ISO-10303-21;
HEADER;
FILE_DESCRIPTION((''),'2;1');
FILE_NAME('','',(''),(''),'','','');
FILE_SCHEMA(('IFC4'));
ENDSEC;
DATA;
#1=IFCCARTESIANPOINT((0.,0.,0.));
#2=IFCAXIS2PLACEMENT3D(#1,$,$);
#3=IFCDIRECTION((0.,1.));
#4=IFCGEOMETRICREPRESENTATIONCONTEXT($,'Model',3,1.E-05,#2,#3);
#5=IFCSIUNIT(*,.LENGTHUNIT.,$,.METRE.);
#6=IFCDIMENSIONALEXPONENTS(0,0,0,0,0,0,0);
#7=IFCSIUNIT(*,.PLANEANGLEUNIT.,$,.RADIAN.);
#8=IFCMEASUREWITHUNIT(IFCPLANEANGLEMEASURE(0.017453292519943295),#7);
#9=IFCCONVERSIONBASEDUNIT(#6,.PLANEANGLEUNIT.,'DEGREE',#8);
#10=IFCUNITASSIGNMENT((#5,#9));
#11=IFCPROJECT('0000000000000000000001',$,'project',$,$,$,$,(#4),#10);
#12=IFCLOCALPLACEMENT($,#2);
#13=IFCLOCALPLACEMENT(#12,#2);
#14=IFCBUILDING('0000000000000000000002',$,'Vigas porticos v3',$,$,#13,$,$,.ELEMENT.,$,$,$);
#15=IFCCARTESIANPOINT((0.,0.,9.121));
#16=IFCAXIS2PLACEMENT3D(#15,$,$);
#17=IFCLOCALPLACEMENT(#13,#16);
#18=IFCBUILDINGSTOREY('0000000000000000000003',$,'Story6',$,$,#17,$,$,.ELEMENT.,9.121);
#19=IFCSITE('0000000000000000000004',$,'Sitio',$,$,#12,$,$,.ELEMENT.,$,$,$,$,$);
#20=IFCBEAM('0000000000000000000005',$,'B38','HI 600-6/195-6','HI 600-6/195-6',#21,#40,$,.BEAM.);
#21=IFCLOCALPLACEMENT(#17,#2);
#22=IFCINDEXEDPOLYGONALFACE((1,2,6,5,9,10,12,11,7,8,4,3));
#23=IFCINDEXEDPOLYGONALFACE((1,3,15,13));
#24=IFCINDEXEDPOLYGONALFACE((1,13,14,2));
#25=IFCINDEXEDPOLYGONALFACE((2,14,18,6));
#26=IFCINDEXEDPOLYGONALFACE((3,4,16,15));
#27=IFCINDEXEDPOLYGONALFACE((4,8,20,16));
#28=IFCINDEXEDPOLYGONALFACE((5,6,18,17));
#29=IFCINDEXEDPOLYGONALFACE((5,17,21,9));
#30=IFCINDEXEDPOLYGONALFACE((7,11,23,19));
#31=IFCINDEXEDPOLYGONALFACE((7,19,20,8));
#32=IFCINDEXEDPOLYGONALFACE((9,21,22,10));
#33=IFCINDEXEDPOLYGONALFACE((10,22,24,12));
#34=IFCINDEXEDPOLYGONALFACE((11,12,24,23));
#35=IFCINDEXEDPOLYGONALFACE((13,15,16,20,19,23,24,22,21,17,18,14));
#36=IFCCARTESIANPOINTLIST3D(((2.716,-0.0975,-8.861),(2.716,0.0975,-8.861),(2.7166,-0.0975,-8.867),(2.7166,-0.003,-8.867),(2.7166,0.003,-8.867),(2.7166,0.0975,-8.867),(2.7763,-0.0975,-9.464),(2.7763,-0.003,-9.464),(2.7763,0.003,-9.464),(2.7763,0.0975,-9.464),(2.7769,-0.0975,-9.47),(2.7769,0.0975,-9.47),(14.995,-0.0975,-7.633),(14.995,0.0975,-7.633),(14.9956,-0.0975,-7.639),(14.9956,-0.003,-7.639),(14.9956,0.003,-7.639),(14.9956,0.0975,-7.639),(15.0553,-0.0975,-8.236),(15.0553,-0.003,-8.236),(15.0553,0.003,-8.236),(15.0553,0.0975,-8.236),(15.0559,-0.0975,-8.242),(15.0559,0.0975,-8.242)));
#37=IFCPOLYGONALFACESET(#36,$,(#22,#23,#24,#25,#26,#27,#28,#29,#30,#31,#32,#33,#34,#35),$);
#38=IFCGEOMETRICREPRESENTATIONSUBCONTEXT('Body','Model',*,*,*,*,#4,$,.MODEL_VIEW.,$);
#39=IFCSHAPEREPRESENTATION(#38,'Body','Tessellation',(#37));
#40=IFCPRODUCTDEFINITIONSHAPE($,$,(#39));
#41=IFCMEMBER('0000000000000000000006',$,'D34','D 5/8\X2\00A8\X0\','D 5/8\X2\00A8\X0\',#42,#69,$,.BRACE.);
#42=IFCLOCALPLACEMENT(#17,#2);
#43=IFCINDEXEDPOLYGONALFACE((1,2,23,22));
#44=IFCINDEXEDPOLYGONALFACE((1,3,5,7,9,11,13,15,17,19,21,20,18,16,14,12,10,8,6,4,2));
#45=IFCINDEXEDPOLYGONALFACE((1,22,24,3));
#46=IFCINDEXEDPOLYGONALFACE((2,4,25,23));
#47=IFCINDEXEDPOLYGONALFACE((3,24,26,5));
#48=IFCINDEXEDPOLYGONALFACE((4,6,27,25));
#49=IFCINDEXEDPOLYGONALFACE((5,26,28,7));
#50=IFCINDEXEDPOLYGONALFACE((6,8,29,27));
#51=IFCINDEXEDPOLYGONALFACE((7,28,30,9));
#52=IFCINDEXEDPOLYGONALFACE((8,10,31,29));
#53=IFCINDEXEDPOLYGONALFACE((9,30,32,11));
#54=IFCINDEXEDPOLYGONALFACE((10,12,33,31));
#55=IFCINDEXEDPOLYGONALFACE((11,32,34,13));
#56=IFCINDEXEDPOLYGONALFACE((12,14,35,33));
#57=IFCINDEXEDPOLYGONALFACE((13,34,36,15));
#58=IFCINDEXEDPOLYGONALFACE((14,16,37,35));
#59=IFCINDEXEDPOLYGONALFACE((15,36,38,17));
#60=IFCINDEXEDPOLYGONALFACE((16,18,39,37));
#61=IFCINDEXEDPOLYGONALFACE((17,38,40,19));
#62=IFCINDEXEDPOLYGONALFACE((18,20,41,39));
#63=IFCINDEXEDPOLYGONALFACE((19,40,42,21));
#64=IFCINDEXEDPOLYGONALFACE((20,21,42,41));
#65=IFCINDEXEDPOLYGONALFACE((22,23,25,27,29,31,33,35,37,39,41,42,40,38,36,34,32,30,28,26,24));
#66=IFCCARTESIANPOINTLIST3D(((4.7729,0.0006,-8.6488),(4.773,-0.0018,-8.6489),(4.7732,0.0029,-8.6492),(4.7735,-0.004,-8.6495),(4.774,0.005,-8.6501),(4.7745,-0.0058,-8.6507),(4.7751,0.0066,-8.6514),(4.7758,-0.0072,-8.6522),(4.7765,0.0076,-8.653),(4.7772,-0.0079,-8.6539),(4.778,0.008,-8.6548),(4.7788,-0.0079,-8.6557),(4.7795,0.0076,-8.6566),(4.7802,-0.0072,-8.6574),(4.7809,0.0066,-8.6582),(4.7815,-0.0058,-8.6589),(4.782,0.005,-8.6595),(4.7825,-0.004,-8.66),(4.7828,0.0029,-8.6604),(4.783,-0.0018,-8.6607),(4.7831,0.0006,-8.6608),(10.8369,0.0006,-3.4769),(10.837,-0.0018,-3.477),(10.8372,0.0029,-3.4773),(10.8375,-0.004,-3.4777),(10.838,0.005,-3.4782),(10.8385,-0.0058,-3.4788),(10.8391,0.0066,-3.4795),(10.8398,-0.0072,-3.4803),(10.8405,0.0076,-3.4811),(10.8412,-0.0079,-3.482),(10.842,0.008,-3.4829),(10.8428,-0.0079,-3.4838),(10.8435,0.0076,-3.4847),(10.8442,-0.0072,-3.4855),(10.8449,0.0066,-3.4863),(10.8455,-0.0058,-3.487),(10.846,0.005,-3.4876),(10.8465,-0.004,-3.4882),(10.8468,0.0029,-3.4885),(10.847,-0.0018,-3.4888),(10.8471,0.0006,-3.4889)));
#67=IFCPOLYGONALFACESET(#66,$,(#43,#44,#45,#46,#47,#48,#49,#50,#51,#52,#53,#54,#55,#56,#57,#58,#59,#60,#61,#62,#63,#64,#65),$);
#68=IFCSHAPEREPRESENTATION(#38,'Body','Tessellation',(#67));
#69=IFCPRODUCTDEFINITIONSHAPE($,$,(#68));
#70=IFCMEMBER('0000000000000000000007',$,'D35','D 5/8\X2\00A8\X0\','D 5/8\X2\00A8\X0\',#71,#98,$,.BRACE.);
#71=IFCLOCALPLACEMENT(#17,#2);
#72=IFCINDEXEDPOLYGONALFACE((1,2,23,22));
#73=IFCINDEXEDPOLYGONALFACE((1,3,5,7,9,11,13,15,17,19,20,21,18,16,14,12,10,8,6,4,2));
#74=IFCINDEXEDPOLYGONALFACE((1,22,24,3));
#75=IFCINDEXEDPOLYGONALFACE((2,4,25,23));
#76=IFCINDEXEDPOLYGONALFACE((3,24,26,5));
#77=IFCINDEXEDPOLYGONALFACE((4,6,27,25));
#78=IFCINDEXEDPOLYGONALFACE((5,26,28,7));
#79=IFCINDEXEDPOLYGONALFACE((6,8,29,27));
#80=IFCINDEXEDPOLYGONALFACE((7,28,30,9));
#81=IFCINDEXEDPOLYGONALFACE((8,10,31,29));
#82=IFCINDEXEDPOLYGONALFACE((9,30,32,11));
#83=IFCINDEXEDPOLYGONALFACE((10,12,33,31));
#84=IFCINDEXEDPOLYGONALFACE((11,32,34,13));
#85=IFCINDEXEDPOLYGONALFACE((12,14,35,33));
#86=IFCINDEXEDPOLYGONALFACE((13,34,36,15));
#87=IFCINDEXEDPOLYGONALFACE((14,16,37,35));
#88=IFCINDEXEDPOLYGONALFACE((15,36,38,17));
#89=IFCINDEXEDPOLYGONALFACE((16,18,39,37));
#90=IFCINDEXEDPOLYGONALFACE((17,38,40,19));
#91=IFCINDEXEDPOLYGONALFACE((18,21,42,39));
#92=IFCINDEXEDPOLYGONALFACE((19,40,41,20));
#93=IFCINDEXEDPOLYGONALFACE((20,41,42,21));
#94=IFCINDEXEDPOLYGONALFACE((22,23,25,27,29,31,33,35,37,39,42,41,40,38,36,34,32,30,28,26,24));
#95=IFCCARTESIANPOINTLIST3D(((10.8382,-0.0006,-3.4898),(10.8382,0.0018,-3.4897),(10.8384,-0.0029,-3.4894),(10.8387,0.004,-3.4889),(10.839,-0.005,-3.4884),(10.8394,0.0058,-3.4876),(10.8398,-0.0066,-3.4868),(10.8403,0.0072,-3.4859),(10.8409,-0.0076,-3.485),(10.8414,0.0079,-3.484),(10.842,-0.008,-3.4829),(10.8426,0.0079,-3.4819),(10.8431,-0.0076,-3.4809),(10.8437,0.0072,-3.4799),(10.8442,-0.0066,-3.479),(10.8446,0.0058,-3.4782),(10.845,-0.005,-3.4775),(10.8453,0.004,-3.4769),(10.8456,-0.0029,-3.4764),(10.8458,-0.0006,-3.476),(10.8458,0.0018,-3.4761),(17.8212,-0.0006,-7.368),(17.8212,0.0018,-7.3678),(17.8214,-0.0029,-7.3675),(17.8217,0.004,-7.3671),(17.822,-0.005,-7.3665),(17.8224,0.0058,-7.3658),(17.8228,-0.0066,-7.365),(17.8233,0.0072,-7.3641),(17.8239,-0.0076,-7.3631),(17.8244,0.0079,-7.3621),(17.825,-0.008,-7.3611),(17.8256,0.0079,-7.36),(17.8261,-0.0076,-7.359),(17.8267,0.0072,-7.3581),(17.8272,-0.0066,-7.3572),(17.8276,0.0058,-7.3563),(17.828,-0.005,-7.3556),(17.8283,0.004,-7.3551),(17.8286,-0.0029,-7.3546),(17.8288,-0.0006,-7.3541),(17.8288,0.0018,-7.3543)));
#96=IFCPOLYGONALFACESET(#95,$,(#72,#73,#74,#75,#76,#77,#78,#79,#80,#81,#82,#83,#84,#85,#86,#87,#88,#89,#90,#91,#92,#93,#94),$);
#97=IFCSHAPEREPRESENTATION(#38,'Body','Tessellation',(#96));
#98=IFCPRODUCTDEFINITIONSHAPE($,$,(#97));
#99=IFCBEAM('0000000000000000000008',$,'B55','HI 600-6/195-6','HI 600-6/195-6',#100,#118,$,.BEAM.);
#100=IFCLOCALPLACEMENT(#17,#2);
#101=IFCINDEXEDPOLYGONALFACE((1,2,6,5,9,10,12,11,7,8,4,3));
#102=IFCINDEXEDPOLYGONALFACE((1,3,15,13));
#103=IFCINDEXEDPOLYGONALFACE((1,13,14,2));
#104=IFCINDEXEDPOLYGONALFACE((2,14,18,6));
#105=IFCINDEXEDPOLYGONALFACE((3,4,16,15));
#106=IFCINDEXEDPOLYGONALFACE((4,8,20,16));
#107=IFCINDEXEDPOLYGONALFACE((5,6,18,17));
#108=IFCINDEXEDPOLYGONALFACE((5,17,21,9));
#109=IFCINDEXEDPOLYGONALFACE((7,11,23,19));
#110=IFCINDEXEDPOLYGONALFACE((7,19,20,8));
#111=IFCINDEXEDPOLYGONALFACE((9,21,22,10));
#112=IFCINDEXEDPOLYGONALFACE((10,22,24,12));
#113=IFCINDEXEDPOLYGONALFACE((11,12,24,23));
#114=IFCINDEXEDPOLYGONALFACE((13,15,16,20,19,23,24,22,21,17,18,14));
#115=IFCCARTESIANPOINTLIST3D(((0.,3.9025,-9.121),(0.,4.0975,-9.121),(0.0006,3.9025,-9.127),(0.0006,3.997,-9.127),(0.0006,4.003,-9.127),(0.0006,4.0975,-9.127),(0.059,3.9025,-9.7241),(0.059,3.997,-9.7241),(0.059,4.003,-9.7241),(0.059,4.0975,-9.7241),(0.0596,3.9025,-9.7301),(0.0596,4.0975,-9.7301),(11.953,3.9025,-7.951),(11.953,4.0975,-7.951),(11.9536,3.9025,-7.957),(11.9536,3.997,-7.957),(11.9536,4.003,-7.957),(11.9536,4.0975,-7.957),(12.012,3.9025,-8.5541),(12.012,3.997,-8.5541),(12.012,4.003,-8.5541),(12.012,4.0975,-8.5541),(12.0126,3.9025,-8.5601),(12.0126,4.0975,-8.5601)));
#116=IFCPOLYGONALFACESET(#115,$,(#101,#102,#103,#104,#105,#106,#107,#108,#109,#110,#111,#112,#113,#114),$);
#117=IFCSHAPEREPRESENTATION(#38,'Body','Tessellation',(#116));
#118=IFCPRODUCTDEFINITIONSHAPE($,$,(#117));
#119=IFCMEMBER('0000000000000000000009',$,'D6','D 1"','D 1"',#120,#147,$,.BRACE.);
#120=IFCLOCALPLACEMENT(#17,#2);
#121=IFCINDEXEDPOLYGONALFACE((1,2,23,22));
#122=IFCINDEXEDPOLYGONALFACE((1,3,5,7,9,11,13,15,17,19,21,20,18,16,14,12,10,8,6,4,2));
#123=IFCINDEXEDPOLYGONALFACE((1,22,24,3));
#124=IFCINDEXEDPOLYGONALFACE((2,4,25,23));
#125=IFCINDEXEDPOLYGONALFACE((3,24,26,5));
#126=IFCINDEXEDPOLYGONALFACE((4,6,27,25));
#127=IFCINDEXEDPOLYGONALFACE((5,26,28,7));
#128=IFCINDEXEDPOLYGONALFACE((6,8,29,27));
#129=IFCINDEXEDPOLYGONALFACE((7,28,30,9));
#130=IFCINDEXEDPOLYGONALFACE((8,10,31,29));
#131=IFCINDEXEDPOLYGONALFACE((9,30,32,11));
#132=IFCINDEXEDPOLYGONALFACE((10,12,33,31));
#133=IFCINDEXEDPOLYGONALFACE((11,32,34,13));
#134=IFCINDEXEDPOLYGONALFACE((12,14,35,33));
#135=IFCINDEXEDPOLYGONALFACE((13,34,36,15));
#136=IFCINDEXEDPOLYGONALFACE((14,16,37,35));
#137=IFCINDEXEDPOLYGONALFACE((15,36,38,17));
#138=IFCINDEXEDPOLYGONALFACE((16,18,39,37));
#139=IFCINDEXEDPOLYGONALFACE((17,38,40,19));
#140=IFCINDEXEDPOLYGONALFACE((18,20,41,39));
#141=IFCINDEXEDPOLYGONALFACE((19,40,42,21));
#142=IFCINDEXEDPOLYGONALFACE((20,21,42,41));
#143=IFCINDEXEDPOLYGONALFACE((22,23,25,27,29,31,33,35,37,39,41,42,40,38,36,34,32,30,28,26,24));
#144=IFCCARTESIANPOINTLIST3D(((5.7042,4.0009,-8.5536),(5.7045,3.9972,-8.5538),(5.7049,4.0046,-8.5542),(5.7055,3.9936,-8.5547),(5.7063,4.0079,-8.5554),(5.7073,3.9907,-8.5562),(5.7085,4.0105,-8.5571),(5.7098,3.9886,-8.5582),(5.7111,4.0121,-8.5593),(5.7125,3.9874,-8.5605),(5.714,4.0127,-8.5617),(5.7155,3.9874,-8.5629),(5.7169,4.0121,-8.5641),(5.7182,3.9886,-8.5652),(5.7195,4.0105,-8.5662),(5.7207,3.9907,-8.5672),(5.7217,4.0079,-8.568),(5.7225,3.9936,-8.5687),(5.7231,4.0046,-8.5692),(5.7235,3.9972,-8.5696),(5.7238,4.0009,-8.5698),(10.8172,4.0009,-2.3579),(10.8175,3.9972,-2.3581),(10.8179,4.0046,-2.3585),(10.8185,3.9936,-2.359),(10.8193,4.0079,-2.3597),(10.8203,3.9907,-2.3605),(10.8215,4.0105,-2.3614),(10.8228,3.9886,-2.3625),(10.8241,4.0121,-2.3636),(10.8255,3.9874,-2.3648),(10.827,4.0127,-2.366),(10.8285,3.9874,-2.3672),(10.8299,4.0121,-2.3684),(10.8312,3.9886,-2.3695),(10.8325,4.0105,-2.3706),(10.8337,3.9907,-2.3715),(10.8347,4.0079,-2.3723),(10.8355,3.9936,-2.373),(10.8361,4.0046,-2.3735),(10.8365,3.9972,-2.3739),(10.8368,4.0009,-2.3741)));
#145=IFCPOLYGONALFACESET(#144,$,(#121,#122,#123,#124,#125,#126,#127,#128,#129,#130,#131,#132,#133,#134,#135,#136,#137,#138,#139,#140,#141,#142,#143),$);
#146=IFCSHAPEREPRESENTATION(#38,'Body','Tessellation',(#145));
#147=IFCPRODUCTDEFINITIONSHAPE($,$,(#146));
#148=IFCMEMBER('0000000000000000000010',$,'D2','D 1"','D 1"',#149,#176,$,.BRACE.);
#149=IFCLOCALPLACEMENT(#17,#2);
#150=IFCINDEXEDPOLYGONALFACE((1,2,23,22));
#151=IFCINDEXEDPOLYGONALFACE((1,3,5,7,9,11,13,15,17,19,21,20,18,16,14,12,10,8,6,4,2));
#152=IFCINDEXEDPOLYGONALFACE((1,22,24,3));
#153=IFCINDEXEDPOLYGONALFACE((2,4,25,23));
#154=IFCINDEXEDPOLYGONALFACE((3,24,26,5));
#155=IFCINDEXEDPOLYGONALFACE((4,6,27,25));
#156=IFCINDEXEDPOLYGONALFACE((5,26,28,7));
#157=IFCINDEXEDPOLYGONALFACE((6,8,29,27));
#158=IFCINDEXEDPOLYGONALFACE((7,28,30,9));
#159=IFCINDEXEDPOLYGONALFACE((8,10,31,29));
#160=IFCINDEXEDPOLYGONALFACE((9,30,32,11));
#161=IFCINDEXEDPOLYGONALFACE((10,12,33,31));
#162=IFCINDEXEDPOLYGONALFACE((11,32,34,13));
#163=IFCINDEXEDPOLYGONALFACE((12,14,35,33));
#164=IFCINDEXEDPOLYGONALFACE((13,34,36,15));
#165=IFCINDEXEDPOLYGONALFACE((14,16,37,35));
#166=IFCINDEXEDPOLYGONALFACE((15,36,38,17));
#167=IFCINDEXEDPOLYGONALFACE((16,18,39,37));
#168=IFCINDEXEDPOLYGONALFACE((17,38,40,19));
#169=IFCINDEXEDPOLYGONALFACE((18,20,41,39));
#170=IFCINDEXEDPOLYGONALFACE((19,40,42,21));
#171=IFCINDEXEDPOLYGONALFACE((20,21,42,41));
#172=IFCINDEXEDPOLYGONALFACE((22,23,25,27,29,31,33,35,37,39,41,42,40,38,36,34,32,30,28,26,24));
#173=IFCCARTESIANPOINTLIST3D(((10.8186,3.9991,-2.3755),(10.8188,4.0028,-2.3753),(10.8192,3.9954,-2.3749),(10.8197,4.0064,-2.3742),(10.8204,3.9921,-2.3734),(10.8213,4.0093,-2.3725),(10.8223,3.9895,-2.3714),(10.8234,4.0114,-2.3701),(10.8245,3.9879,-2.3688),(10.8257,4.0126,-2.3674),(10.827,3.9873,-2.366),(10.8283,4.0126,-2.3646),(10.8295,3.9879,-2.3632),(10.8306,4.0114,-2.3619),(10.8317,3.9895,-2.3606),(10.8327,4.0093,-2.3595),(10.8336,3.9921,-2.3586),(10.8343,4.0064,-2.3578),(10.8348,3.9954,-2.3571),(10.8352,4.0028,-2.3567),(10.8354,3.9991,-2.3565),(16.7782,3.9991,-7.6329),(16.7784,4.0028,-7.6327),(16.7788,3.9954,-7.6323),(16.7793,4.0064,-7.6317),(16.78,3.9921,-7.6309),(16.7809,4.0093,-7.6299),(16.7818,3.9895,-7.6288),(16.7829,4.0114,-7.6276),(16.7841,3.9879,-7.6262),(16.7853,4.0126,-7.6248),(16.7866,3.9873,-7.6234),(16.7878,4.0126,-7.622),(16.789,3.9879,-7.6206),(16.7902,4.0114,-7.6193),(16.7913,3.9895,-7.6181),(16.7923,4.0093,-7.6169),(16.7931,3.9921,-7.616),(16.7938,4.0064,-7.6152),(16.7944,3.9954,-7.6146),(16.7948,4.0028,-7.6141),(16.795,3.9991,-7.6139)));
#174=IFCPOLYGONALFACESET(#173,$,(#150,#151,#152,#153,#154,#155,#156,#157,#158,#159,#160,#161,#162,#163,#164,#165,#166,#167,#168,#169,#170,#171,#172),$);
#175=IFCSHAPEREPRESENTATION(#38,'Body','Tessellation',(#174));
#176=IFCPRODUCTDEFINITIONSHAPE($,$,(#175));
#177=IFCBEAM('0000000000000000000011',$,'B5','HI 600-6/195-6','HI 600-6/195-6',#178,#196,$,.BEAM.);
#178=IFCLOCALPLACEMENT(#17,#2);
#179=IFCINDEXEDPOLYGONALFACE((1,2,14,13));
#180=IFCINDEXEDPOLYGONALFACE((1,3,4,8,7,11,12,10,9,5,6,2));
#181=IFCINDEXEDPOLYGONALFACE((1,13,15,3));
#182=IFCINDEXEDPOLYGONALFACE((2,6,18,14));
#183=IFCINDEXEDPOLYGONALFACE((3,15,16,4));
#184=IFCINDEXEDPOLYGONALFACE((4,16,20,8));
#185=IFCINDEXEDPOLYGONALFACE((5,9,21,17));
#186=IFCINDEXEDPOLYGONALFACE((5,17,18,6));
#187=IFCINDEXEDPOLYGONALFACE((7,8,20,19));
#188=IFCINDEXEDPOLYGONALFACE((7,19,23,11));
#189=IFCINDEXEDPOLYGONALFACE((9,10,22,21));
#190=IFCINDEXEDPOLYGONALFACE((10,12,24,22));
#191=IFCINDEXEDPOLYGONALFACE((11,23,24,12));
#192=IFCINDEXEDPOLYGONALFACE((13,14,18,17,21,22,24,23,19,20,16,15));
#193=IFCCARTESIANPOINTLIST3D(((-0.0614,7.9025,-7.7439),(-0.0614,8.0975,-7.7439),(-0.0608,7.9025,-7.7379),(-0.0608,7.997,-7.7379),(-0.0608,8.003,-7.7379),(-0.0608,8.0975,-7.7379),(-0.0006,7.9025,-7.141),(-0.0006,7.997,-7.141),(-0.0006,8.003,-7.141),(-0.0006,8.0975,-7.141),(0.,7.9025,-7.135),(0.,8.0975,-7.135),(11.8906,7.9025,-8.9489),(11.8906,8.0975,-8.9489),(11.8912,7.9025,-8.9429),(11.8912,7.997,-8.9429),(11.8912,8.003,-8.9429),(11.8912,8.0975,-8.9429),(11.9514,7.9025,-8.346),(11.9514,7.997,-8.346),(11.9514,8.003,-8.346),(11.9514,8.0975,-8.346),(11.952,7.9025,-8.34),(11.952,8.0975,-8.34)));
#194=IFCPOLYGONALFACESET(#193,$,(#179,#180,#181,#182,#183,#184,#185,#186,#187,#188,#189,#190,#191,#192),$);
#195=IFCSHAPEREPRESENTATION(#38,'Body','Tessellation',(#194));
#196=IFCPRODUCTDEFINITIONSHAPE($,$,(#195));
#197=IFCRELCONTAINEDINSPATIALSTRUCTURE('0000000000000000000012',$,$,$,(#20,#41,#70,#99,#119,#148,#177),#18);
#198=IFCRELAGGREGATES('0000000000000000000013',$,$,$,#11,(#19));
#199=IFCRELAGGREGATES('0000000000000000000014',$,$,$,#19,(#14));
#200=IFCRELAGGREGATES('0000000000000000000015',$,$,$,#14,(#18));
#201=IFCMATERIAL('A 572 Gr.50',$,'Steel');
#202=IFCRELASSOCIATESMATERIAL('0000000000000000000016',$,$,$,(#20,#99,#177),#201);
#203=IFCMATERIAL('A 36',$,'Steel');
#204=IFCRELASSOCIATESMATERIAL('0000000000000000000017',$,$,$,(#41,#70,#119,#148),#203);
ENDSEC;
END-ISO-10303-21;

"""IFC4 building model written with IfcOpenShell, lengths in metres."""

from ifc_helpers import new_model, entity, si_unit, converted_unit, direction, frame, origin, place, context, subcontext, project, spatial, circle, i_section, extrude, material, element, save


model = new_model("IFC4")

# Units and contexts
model_context = context("Model", 3, precision=1e-05, world=origin(), true_north=direction((0.0, 1.0)))
body_context = subcontext(model_context, "Body", "Model", "MODEL_VIEW")
ifc_project = project(units=[si_unit("LENGTHUNIT", "METRE"), converted_unit("PLANEANGLEUNIT", "DEGREE", entity("IfcPlaneAngleMeasure", 0.017453292519943295), si_unit("PLANEANGLEUNIT", "RADIAN"), dimensions=[0, 0, 0, 0, 0, 0, 0])], contexts=[model_context])

# Site, building, storey
site_placement = place(None, origin())
site = spatial("IfcSite", under=ifc_project, at=site_placement, Name="Sitio", CompositionType="ELEMENT")
building_placement = place(site_placement, origin())
building = spatial("IfcBuilding", under=site, at=building_placement, Name="Vigas porticos v3", CompositionType="ELEMENT")
storey_placement = place(building_placement, frame((0.0, 0.0, 9.121)))
storey = spatial("IfcBuildingStorey", under=building, at=storey_placement, Name="Story6", CompositionType="ELEMENT", Elevation=9.121)

# Beam
ifc_material_1 = material(Name="A 572 Gr.50", Category="Steel")
beam_1_placement = place(storey_placement, frame((2.716, 0.0, -8.861), z_axis=(0.995036, 0.0, 0.099512), x_axis=(0.0, 1.0, 0.0)))
element("IfcBeam", 1, at=beam_1_placement, inside=storey, material=ifc_material_1, Name="B38", Description="HI 600-6/195-6", ObjectType="HI 600-6/195-6", PredefinedType="BEAM", context=body_context, shape_type="SweptSolid", body=[
    extrude(i_section(OverallWidth=0.195, OverallDepth=0.612, WebThickness=0.006, FlangeThickness=0.006), frame((0.0, -0.306, 0.0)), (0.0, 0.0, 1.0), 12.3403),
])

# Members
ifc_material_2 = material(Name="A 36", Category="Steel")
member_1_placement = place(storey_placement, frame((4.778, 0.0, -8.6548), z_axis=(0.760857, 0.0, 0.64892), x_axis=(0.0, 1.0, 0.0)))
element("IfcMember", 2, at=member_1_placement, inside=storey, material=ifc_material_2, Name="D34", Description="D 5/8¨", ObjectType="D 5/8¨", PredefinedType="BRACE", context=body_context, shape_type="SweptSolid", body=[
    extrude(circle(Radius=0.008), origin(), (0.0, 0.0, 1.0), 7.97),
])
member_2_placement = place(storey_placement, frame((17.825, 0.0, -7.3611), z_axis=(-0.874226, 0.0, 0.48552), x_axis=(0.0, -1.0, 0.0)))
element("IfcMember", 3, at=member_2_placement, inside=storey, material=ifc_material_2, Name="D35", Description="D 5/8¨", ObjectType="D 5/8¨", PredefinedType="BRACE", context=body_context, shape_type="SweptSolid", body=[
    extrude(circle(Radius=0.008), origin(), (0.0, 0.0, 1.0), 7.9876),
])

# Beam
beam_2_placement = place(storey_placement, frame((0.0, 4.0, -9.121), z_axis=(0.995244, 0.0, 0.097418), x_axis=(0.0, 1.0, 0.0)))
element("IfcBeam", 4, at=beam_2_placement, inside=storey, material=ifc_material_1, Name="B55", Description="HI 600-6/195-6", ObjectType="HI 600-6/195-6", PredefinedType="BEAM", context=body_context, shape_type="SweptSolid", body=[
    extrude(i_section(OverallWidth=0.195, OverallDepth=0.612, WebThickness=0.006, FlangeThickness=0.006), frame((0.0, -0.306, 0.0)), (0.0, 0.0, 1.0), 12.0101),
])

# Members
member_3_placement = place(storey_placement, frame((5.714, 4.0, -8.5617), z_axis=(0.636498, 0.0, 0.771278), x_axis=(0.0, 1.0, 0.0)))
element("IfcMember", 5, at=member_3_placement, inside=storey, material=ifc_material_2, Name="D6", Description="D 1\"", ObjectType="D 1\"", PredefinedType="BRACE", context=body_context, shape_type="SweptSolid", body=[
    extrude(circle(Radius=0.0127), origin(), (0.0, 0.0, 1.0), 8.033),
])
member_4_placement = place(storey_placement, frame((16.7866, 4.0, -7.6234), z_axis=(-0.749902, 0.0, 0.661549), x_axis=(0.0, -1.0, 0.0)))
element("IfcMember", 6, at=member_4_placement, inside=storey, material=ifc_material_2, Name="D2", Description="D 1\"", ObjectType="D 1\"", PredefinedType="BRACE", context=body_context, shape_type="SweptSolid", body=[
    extrude(circle(Radius=0.0127), origin(), (0.0, 0.0, 1.0), 7.9471),
])

# Beam
beam_3_placement = place(storey_placement, frame((11.952, 8.0, -8.34), z_axis=(-0.994956, 0.0, 0.100311), x_axis=(0.0, -1.0, 0.0)))
element("IfcBeam", 7, at=beam_3_placement, inside=storey, material=ifc_material_1, Name="B5", Description="HI 600-6/195-6", ObjectType="HI 600-6/195-6", PredefinedType="BEAM", context=body_context, shape_type="SweptSolid", body=[
    extrude(i_section(OverallWidth=0.195, OverallDepth=0.612, WebThickness=0.006, FlangeThickness=0.006), frame((0.0, -0.306, 0.0)), (0.0, 0.0, 1.0), 12.0126),
])

save(model, "model.ifc")
